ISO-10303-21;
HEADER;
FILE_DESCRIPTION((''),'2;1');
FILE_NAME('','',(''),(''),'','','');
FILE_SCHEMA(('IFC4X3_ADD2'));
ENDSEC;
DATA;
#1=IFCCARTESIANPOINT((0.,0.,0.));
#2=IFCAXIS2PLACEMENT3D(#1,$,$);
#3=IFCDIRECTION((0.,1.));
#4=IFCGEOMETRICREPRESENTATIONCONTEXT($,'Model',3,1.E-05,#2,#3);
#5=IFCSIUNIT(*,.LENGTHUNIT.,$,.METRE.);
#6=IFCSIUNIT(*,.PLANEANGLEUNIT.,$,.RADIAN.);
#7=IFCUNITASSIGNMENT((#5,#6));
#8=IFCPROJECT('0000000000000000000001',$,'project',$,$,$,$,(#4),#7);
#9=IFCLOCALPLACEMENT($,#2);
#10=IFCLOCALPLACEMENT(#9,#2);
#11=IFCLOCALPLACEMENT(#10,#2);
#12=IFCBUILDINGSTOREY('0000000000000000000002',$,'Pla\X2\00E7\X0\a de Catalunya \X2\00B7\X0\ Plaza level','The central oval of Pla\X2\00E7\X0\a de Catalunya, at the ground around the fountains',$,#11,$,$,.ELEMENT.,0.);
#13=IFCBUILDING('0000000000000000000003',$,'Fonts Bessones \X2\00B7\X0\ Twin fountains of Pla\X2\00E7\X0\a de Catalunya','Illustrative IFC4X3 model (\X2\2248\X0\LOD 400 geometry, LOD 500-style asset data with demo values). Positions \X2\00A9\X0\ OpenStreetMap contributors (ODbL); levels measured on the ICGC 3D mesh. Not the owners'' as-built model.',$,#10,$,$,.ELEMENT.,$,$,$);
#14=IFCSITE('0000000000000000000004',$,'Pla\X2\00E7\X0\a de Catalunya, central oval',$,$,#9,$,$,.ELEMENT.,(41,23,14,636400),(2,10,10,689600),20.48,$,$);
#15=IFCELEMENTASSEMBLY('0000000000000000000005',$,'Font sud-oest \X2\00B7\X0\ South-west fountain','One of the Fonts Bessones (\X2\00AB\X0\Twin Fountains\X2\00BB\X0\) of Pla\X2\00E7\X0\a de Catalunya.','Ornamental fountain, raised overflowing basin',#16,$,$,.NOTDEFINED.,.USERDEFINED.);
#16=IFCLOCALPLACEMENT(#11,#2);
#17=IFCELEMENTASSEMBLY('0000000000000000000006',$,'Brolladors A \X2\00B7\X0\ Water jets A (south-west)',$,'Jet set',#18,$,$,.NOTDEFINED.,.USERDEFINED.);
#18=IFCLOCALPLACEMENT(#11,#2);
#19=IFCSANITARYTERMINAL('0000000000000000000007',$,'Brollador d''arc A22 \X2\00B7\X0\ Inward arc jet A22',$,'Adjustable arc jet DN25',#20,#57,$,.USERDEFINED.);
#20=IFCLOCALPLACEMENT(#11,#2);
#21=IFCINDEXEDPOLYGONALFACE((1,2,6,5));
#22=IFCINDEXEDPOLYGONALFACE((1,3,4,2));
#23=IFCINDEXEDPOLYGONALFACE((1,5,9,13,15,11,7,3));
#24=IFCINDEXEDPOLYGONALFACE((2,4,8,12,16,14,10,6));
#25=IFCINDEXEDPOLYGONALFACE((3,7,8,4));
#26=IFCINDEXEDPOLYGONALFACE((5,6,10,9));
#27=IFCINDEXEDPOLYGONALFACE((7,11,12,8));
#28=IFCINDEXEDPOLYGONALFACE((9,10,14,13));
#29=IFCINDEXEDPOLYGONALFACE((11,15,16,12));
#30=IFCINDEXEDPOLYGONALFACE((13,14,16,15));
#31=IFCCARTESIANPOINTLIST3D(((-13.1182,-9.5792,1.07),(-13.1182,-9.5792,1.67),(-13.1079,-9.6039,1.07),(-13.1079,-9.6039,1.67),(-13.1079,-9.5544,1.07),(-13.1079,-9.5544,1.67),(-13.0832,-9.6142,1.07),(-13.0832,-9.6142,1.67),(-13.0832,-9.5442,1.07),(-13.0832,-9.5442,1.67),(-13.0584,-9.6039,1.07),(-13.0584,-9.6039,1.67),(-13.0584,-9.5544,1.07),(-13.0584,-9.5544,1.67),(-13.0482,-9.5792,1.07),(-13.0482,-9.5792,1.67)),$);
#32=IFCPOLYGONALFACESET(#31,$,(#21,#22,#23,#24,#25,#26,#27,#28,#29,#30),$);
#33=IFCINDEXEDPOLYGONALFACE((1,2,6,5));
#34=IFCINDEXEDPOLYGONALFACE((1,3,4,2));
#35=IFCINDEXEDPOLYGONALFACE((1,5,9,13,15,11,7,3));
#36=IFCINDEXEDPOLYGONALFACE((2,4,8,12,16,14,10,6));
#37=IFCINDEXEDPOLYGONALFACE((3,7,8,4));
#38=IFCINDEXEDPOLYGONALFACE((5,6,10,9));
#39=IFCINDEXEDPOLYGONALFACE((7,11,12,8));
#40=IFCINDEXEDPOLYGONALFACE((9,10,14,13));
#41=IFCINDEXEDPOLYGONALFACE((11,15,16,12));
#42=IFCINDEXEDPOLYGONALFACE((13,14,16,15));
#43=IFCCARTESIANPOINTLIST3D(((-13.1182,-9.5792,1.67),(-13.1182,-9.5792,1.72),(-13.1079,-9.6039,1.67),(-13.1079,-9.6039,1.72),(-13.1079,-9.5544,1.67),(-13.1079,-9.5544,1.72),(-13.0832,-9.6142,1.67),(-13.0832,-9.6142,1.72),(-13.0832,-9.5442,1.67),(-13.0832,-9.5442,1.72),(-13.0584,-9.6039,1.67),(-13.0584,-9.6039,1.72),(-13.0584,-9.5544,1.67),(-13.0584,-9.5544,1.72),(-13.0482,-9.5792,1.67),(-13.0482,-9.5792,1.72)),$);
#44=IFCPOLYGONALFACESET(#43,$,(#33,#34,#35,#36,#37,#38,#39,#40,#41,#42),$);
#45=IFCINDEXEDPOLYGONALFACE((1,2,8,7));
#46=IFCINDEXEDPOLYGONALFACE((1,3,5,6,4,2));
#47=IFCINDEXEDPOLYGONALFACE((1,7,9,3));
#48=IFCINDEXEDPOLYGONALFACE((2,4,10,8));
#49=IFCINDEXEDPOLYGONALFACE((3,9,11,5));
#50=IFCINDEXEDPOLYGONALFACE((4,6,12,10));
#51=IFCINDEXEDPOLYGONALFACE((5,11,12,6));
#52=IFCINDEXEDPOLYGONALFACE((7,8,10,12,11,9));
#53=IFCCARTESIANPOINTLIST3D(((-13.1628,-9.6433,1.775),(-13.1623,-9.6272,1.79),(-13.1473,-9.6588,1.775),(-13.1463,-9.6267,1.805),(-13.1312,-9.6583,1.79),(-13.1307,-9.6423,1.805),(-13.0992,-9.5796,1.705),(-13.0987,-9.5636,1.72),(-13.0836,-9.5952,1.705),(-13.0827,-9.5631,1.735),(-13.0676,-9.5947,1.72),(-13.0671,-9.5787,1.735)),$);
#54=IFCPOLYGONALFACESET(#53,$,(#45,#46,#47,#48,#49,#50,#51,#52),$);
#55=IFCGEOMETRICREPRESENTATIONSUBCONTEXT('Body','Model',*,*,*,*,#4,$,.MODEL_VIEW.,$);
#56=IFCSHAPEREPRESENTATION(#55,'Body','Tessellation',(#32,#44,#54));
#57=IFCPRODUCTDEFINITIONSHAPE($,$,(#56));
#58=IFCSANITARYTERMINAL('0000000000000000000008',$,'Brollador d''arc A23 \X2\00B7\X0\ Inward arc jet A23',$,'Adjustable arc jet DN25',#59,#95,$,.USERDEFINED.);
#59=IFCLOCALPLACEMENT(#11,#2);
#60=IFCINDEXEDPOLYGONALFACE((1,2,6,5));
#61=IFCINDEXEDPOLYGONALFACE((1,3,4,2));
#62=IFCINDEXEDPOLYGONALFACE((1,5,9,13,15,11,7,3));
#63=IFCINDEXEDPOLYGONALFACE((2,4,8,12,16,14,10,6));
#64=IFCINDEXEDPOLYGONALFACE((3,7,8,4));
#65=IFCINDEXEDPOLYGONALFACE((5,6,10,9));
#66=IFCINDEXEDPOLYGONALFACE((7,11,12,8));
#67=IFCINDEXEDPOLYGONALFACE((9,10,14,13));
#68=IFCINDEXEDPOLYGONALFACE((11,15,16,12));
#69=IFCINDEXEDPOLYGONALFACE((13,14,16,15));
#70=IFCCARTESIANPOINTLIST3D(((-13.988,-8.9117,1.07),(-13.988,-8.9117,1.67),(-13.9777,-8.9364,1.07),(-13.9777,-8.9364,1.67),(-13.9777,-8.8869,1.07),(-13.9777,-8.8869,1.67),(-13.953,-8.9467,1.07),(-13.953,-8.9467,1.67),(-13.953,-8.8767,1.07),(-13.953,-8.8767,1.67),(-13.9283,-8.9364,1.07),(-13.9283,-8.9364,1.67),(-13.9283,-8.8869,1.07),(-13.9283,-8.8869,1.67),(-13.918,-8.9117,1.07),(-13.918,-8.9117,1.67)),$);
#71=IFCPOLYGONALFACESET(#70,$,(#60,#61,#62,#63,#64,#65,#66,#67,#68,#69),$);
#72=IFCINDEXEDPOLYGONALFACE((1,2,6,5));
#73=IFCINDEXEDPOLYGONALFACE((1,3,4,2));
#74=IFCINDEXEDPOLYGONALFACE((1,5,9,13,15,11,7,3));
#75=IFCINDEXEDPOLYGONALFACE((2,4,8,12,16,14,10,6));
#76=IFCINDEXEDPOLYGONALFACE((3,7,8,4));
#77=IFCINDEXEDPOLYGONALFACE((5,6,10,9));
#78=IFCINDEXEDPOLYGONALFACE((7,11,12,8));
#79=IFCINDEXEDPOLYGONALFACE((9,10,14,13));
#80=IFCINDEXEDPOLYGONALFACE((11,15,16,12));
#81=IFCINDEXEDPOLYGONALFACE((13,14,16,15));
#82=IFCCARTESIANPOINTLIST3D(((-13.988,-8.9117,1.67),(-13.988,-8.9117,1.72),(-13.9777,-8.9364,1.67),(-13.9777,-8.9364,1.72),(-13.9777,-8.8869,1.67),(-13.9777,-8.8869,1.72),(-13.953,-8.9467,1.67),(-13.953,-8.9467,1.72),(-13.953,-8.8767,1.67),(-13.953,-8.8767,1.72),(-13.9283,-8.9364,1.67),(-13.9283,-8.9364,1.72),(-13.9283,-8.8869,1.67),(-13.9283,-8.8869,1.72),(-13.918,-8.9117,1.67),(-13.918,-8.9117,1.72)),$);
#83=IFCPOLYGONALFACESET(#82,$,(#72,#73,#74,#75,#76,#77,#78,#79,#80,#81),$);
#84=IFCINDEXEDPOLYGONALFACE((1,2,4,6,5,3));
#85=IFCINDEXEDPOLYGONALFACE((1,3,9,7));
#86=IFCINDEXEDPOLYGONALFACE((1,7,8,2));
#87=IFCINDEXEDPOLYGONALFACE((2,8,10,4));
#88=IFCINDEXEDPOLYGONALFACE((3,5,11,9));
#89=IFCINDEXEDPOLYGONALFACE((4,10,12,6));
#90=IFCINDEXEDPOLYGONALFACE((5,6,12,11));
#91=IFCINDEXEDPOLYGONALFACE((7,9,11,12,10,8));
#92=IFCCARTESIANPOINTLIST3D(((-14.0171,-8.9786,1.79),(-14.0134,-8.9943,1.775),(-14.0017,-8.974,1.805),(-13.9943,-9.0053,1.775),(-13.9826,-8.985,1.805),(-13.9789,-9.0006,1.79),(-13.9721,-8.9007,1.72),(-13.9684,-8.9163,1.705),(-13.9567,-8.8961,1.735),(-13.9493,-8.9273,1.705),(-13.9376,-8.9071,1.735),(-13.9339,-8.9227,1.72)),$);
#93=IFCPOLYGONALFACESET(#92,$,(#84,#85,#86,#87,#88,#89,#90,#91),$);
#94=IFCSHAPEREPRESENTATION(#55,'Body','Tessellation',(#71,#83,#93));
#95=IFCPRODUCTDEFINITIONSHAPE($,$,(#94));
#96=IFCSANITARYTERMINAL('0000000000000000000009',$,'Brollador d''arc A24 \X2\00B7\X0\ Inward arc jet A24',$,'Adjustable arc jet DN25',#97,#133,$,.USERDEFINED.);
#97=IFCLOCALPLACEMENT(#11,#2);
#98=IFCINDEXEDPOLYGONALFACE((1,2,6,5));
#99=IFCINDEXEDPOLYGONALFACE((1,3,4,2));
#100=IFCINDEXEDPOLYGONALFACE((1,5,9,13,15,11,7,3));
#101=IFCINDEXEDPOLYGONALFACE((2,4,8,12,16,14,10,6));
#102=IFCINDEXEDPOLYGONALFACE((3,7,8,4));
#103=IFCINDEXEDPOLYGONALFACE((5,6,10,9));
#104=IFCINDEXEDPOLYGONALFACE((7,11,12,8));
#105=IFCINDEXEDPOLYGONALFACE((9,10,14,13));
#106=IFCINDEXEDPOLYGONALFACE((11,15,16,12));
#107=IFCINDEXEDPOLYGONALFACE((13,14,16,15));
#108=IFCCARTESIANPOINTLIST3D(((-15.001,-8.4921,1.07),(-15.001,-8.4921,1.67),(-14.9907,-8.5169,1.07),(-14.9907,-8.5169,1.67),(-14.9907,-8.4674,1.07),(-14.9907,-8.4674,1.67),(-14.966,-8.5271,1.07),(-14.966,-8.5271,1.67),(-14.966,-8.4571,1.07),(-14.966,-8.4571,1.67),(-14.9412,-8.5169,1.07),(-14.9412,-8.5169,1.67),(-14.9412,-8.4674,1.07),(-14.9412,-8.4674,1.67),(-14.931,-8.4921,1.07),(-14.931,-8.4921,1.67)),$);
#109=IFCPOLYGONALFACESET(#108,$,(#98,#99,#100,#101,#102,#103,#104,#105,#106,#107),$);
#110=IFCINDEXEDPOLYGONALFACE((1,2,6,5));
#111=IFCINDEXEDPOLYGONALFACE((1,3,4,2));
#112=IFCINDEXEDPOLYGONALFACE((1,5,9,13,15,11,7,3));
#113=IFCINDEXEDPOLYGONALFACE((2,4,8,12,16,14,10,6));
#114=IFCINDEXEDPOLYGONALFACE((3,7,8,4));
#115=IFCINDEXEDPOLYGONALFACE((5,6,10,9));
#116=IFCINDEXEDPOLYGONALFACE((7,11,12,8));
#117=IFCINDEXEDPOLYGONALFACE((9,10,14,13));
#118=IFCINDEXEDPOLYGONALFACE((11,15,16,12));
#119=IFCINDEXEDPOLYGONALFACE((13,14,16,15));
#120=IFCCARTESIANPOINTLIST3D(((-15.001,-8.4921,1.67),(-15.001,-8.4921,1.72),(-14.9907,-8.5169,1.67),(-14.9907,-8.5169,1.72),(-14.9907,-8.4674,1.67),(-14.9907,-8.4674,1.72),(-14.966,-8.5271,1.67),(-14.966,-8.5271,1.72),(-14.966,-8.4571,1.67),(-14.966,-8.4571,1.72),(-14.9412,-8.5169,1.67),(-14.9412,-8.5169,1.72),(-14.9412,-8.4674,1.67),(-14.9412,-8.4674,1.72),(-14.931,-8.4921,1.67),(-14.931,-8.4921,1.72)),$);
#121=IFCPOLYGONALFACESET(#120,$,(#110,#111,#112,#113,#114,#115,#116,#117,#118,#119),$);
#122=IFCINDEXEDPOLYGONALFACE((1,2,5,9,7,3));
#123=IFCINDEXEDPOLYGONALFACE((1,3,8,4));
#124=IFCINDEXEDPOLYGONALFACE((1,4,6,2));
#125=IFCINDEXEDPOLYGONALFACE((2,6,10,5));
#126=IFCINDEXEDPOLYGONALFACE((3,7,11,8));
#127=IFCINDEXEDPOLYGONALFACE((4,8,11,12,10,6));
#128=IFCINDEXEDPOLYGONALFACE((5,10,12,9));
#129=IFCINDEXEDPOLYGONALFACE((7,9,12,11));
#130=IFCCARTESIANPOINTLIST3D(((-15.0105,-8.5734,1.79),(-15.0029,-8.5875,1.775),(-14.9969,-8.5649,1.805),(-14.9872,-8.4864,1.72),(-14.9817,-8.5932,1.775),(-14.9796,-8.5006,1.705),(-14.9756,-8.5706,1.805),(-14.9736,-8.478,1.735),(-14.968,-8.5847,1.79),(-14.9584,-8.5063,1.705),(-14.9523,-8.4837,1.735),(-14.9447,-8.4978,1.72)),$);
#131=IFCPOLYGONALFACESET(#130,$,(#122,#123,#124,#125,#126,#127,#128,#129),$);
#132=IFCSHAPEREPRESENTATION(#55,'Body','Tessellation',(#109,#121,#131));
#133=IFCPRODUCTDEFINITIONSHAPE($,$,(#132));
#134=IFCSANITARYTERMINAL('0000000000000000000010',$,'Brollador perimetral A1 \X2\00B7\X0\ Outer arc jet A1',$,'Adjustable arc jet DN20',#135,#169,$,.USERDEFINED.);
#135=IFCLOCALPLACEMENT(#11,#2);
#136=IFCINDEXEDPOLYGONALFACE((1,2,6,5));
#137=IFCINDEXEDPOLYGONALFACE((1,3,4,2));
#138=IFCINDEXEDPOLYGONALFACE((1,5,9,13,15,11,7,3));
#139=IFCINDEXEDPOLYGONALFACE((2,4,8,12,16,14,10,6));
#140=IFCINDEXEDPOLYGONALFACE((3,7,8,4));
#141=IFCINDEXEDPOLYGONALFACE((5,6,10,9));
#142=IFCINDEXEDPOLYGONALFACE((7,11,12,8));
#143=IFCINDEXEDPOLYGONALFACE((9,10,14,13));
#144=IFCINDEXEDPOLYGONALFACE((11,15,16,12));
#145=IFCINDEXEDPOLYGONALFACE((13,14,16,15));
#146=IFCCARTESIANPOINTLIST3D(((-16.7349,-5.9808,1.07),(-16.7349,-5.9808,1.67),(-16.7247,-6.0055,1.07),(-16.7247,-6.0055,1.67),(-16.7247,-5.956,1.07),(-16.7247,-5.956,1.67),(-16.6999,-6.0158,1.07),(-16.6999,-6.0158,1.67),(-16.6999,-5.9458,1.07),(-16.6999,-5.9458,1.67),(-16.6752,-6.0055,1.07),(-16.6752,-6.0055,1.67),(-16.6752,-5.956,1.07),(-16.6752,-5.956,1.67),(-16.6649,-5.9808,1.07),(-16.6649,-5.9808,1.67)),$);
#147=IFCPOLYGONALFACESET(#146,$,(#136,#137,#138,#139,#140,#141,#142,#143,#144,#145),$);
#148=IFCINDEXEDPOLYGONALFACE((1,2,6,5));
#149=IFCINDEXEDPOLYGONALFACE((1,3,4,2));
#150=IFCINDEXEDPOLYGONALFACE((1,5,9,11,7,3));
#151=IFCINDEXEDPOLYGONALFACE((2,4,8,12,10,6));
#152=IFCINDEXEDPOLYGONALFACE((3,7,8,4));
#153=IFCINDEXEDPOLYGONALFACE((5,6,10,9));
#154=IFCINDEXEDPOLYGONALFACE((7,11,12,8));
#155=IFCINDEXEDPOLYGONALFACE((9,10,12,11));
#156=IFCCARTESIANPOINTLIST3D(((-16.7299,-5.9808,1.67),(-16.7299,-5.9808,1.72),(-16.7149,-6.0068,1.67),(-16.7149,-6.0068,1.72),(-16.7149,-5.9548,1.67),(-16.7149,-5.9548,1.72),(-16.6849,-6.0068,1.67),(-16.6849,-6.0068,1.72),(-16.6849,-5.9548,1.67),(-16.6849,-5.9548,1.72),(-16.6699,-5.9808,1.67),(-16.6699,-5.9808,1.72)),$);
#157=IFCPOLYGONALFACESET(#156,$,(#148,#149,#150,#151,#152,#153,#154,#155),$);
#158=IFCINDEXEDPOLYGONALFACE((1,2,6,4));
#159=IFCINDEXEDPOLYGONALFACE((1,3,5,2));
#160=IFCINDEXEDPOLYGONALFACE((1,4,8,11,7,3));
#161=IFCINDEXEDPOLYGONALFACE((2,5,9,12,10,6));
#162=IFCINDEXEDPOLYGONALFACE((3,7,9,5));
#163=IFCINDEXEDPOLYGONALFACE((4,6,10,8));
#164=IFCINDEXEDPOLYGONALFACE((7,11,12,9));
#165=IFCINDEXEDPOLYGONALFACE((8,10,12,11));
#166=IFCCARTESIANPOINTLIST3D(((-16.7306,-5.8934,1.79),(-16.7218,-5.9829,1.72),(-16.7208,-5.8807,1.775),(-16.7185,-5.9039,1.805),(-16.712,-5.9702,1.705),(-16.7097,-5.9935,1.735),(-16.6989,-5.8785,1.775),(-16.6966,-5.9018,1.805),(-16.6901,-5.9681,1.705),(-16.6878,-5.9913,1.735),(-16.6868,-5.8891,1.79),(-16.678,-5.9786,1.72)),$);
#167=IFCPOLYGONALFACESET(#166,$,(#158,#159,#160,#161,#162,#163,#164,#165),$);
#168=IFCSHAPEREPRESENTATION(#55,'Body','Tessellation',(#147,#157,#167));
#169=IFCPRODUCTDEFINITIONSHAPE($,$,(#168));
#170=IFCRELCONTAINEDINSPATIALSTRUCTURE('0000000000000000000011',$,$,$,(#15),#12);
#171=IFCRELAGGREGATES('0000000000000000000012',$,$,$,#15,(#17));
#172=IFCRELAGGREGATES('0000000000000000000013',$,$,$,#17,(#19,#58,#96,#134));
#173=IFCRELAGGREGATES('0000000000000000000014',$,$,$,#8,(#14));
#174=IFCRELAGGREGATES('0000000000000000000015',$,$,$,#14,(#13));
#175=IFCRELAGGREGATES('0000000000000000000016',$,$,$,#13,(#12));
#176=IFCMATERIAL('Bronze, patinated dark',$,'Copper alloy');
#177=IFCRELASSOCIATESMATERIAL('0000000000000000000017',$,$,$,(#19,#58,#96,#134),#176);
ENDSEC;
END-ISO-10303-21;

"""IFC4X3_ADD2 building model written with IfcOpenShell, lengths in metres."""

from ifc_helpers import new_model, si_unit, direction, frame, origin, place, context, subcontext, project, spatial, polyline, outline, extrude, material, element, aggregate, save


model = new_model("IFC4X3_ADD2")

# Units and contexts
model_context = context("Model", 3, precision=1e-05, world=origin(), true_north=direction((0.0, 1.0)))
body_context = subcontext(model_context, "Body", "Model", "MODEL_VIEW")
ifc_project = project(units=[si_unit("LENGTHUNIT", "METRE"), si_unit("PLANEANGLEUNIT", "RADIAN")], contexts=[model_context])

# Site, building, storey
site_placement = place(None, origin())
site = spatial("IfcSite", under=ifc_project, at=site_placement, Name="Plaça de Catalunya, central oval", CompositionType="ELEMENT", RefLatitude=(41, 23, 14, 636400), RefLongitude=(2, 10, 10, 689600), RefElevation=20.48)
building_placement = place(site_placement, origin())
building = spatial("IfcBuilding", under=site, at=building_placement, Name="Fonts Bessones · Twin fountains of Plaça de Catalunya", Description="Illustrative IFC4X3 model (≈LOD 400 geometry, LOD 500-style asset data with demo values). Positions © OpenStreetMap contributors (ODbL); levels measured on the ICGC 3D mesh. Not the owners' as-built model.", CompositionType="ELEMENT")
storey_placement = place(building_placement, origin())
storey = spatial("IfcBuildingStorey", under=building, at=storey_placement, Name="Plaça de Catalunya · Plaza level", Description="The central oval of Plaça de Catalunya, at the ground around the fountains", CompositionType="ELEMENT", Elevation=0.0)

# Element assemblies, sanitary terminals
assembly_1_placement = place(building_placement, origin())
assembly_1 = element("IfcElementAssembly", 1, at=assembly_1_placement, inside=storey, Name="Font sud-oest · South-west fountain", Description="One of the Fonts Bessones («Twin Fountains») of Plaça de Catalunya.", ObjectType="Ornamental fountain, raised overflowing basin", AssemblyPlace="NOTDEFINED", PredefinedType="USERDEFINED")
assembly_2_placement = place(building_placement, origin())
assembly_2 = element("IfcElementAssembly", 2, at=assembly_2_placement, Name="Brolladors A · Water jets A (south-west)", ObjectType="Jet set", AssemblyPlace="NOTDEFINED", PredefinedType="USERDEFINED")
aggregate(assembly_1, [assembly_2])
ifc_material = material(Name="Bronze, patinated dark", Category="Copper alloy")
sanitary_terminal_1_placement = place(building_placement, origin())
sanitary_terminal_1 = element("IfcSanitaryTerminal", 3, at=sanitary_terminal_1_placement, material=ifc_material, Name="Brollador d'arc A22 · Inward arc jet A22", ObjectType="Adjustable arc jet DN25", PredefinedType="USERDEFINED", context=body_context, shape_type="SweptSolid", body=[
    extrude(outline(polyline([(-13.0482, -9.5792), (-13.0584, -9.5544), (-13.0832, -9.5442), (-13.1079, -9.5544), (-13.1182, -9.5792), (-13.1079, -9.6039), (-13.0832, -9.6142), (-13.0584, -9.6039), (-13.0482, -9.5792)])), frame((0.0, 0.0, 1.07)), (0.0, 0.0, 1.0), 0.6),
    extrude(outline(polyline([(-13.0482, -9.5792), (-13.0584, -9.5544), (-13.0832, -9.5442), (-13.1079, -9.5544), (-13.1182, -9.5792), (-13.1079, -9.6039), (-13.0832, -9.6142), (-13.0584, -9.6039), (-13.0482, -9.5792)])), frame((0.0, 0.0, 1.67)), (0.0, 0.0, 1.0), 0.05),
    extrude(outline(polyline([(0.022, 0.0), (0.011, 0.0191), (-0.011, 0.0191), (-0.022, 0.0), (-0.011, -0.0191), (0.011, -0.0191), (0.022, 0.0)])), frame((-13.0832, -9.5792, 1.72), z_axis=(-0.558156, -0.558156, 0.613941), x_axis=(-0.707107, 0.707107, 0.0)), (0.0, 0.0, 1.0), 0.114),
])
sanitary_terminal_2_placement = place(building_placement, origin())
sanitary_terminal_2 = element("IfcSanitaryTerminal", 4, at=sanitary_terminal_2_placement, material=ifc_material, Name="Brollador d'arc A23 · Inward arc jet A23", ObjectType="Adjustable arc jet DN25", PredefinedType="USERDEFINED", context=body_context, shape_type="SweptSolid", body=[
    extrude(outline(polyline([(-13.918, -8.9117), (-13.9283, -8.8869), (-13.953, -8.8767), (-13.9777, -8.8869), (-13.988, -8.9117), (-13.9777, -8.9364), (-13.953, -8.9467), (-13.9283, -8.9364), (-13.918, -8.9117)])), frame((0.0, 0.0, 1.07)), (0.0, 0.0, 1.0), 0.6),
    extrude(outline(polyline([(-13.918, -8.9117), (-13.9283, -8.8869), (-13.953, -8.8767), (-13.9777, -8.8869), (-13.988, -8.9117), (-13.9777, -8.9364), (-13.953, -8.9467), (-13.9283, -8.9364), (-13.918, -8.9117)])), frame((0.0, 0.0, 1.67)), (0.0, 0.0, 1.0), 0.05),
    extrude(outline(polyline([(0.022, 0.0), (0.011, 0.0191), (-0.011, 0.0191), (-0.022, 0.0), (-0.011, -0.0191), (0.011, -0.0191), (0.022, 0.0)])), frame((-13.953, -8.9117, 1.72), z_axis=(-0.394676, -0.683599, 0.613941), x_axis=(-0.866025, 0.5, 0.0)), (0.0, 0.0, 1.0), 0.114),
])
sanitary_terminal_3_placement = place(building_placement, origin())
sanitary_terminal_3 = element("IfcSanitaryTerminal", 5, at=sanitary_terminal_3_placement, material=ifc_material, Name="Brollador d'arc A24 · Inward arc jet A24", ObjectType="Adjustable arc jet DN25", PredefinedType="USERDEFINED", context=body_context, shape_type="SweptSolid", body=[
    extrude(outline(polyline([(-14.931, -8.4921), (-14.9412, -8.4674), (-14.966, -8.4571), (-14.9907, -8.4674), (-15.001, -8.4921), (-14.9907, -8.5169), (-14.966, -8.5271), (-14.9412, -8.5169), (-14.931, -8.4921)])), frame((0.0, 0.0, 1.07)), (0.0, 0.0, 1.0), 0.6),
    extrude(outline(polyline([(-14.931, -8.4921), (-14.9412, -8.4674), (-14.966, -8.4571), (-14.9907, -8.4674), (-15.001, -8.4921), (-14.9907, -8.5169), (-14.966, -8.5271), (-14.9412, -8.5169), (-14.931, -8.4921)])), frame((0.0, 0.0, 1.67)), (0.0, 0.0, 1.0), 0.05),
    extrude(outline(polyline([(0.022, 0.0), (0.011, 0.0191), (-0.011, 0.0191), (-0.022, 0.0), (-0.011, -0.0191), (0.011, -0.0191), (0.022, 0.0)])), frame((-14.966, -8.4921, 1.72), z_axis=(-0.204299, -0.762456, 0.613941), x_axis=(-0.965926, 0.258819, 0.0)), (0.0, 0.0, 1.0), 0.114),
])
sanitary_terminal_4_placement = place(building_placement, origin())
sanitary_terminal_4 = element("IfcSanitaryTerminal", 6, at=sanitary_terminal_4_placement, material=ifc_material, Name="Brollador perimetral A1 · Outer arc jet A1", ObjectType="Adjustable arc jet DN20", PredefinedType="USERDEFINED", context=body_context, shape_type="SweptSolid", body=[
    extrude(outline(polyline([(-16.6649, -5.9808), (-16.6752, -5.956), (-16.6999, -5.9458), (-16.7247, -5.956), (-16.7349, -5.9808), (-16.7247, -6.0055), (-16.6999, -6.0158), (-16.6752, -6.0055), (-16.6649, -5.9808)])), frame((0.0, 0.0, 1.07)), (0.0, 0.0, 1.0), 0.6),
    extrude(outline(polyline([(-16.6699, -5.9808), (-16.6849, -5.9548), (-16.7149, -5.9548), (-16.7299, -5.9808), (-16.7149, -6.0068), (-16.6849, -6.0068), (-16.6699, -5.9808)])), frame((0.0, 0.0, 1.67)), (0.0, 0.0, 1.0), 0.05),
    extrude(outline(polyline([(0.022, 0.0), (0.011, 0.0191), (-0.011, 0.0191), (-0.022, 0.0), (-0.011, -0.0191), (0.011, -0.0191), (0.022, 0.0)])), frame((-16.6999, -5.9808, 1.72), z_axis=(-0.07737, 0.785551, 0.613941), x_axis=(0.995185, 0.098017, 0.0)), (0.0, 0.0, 1.0), 0.114),
])
aggregate(assembly_2, [sanitary_terminal_1, sanitary_terminal_2, sanitary_terminal_3, sanitary_terminal_4])

save(model, "model.ifc")
